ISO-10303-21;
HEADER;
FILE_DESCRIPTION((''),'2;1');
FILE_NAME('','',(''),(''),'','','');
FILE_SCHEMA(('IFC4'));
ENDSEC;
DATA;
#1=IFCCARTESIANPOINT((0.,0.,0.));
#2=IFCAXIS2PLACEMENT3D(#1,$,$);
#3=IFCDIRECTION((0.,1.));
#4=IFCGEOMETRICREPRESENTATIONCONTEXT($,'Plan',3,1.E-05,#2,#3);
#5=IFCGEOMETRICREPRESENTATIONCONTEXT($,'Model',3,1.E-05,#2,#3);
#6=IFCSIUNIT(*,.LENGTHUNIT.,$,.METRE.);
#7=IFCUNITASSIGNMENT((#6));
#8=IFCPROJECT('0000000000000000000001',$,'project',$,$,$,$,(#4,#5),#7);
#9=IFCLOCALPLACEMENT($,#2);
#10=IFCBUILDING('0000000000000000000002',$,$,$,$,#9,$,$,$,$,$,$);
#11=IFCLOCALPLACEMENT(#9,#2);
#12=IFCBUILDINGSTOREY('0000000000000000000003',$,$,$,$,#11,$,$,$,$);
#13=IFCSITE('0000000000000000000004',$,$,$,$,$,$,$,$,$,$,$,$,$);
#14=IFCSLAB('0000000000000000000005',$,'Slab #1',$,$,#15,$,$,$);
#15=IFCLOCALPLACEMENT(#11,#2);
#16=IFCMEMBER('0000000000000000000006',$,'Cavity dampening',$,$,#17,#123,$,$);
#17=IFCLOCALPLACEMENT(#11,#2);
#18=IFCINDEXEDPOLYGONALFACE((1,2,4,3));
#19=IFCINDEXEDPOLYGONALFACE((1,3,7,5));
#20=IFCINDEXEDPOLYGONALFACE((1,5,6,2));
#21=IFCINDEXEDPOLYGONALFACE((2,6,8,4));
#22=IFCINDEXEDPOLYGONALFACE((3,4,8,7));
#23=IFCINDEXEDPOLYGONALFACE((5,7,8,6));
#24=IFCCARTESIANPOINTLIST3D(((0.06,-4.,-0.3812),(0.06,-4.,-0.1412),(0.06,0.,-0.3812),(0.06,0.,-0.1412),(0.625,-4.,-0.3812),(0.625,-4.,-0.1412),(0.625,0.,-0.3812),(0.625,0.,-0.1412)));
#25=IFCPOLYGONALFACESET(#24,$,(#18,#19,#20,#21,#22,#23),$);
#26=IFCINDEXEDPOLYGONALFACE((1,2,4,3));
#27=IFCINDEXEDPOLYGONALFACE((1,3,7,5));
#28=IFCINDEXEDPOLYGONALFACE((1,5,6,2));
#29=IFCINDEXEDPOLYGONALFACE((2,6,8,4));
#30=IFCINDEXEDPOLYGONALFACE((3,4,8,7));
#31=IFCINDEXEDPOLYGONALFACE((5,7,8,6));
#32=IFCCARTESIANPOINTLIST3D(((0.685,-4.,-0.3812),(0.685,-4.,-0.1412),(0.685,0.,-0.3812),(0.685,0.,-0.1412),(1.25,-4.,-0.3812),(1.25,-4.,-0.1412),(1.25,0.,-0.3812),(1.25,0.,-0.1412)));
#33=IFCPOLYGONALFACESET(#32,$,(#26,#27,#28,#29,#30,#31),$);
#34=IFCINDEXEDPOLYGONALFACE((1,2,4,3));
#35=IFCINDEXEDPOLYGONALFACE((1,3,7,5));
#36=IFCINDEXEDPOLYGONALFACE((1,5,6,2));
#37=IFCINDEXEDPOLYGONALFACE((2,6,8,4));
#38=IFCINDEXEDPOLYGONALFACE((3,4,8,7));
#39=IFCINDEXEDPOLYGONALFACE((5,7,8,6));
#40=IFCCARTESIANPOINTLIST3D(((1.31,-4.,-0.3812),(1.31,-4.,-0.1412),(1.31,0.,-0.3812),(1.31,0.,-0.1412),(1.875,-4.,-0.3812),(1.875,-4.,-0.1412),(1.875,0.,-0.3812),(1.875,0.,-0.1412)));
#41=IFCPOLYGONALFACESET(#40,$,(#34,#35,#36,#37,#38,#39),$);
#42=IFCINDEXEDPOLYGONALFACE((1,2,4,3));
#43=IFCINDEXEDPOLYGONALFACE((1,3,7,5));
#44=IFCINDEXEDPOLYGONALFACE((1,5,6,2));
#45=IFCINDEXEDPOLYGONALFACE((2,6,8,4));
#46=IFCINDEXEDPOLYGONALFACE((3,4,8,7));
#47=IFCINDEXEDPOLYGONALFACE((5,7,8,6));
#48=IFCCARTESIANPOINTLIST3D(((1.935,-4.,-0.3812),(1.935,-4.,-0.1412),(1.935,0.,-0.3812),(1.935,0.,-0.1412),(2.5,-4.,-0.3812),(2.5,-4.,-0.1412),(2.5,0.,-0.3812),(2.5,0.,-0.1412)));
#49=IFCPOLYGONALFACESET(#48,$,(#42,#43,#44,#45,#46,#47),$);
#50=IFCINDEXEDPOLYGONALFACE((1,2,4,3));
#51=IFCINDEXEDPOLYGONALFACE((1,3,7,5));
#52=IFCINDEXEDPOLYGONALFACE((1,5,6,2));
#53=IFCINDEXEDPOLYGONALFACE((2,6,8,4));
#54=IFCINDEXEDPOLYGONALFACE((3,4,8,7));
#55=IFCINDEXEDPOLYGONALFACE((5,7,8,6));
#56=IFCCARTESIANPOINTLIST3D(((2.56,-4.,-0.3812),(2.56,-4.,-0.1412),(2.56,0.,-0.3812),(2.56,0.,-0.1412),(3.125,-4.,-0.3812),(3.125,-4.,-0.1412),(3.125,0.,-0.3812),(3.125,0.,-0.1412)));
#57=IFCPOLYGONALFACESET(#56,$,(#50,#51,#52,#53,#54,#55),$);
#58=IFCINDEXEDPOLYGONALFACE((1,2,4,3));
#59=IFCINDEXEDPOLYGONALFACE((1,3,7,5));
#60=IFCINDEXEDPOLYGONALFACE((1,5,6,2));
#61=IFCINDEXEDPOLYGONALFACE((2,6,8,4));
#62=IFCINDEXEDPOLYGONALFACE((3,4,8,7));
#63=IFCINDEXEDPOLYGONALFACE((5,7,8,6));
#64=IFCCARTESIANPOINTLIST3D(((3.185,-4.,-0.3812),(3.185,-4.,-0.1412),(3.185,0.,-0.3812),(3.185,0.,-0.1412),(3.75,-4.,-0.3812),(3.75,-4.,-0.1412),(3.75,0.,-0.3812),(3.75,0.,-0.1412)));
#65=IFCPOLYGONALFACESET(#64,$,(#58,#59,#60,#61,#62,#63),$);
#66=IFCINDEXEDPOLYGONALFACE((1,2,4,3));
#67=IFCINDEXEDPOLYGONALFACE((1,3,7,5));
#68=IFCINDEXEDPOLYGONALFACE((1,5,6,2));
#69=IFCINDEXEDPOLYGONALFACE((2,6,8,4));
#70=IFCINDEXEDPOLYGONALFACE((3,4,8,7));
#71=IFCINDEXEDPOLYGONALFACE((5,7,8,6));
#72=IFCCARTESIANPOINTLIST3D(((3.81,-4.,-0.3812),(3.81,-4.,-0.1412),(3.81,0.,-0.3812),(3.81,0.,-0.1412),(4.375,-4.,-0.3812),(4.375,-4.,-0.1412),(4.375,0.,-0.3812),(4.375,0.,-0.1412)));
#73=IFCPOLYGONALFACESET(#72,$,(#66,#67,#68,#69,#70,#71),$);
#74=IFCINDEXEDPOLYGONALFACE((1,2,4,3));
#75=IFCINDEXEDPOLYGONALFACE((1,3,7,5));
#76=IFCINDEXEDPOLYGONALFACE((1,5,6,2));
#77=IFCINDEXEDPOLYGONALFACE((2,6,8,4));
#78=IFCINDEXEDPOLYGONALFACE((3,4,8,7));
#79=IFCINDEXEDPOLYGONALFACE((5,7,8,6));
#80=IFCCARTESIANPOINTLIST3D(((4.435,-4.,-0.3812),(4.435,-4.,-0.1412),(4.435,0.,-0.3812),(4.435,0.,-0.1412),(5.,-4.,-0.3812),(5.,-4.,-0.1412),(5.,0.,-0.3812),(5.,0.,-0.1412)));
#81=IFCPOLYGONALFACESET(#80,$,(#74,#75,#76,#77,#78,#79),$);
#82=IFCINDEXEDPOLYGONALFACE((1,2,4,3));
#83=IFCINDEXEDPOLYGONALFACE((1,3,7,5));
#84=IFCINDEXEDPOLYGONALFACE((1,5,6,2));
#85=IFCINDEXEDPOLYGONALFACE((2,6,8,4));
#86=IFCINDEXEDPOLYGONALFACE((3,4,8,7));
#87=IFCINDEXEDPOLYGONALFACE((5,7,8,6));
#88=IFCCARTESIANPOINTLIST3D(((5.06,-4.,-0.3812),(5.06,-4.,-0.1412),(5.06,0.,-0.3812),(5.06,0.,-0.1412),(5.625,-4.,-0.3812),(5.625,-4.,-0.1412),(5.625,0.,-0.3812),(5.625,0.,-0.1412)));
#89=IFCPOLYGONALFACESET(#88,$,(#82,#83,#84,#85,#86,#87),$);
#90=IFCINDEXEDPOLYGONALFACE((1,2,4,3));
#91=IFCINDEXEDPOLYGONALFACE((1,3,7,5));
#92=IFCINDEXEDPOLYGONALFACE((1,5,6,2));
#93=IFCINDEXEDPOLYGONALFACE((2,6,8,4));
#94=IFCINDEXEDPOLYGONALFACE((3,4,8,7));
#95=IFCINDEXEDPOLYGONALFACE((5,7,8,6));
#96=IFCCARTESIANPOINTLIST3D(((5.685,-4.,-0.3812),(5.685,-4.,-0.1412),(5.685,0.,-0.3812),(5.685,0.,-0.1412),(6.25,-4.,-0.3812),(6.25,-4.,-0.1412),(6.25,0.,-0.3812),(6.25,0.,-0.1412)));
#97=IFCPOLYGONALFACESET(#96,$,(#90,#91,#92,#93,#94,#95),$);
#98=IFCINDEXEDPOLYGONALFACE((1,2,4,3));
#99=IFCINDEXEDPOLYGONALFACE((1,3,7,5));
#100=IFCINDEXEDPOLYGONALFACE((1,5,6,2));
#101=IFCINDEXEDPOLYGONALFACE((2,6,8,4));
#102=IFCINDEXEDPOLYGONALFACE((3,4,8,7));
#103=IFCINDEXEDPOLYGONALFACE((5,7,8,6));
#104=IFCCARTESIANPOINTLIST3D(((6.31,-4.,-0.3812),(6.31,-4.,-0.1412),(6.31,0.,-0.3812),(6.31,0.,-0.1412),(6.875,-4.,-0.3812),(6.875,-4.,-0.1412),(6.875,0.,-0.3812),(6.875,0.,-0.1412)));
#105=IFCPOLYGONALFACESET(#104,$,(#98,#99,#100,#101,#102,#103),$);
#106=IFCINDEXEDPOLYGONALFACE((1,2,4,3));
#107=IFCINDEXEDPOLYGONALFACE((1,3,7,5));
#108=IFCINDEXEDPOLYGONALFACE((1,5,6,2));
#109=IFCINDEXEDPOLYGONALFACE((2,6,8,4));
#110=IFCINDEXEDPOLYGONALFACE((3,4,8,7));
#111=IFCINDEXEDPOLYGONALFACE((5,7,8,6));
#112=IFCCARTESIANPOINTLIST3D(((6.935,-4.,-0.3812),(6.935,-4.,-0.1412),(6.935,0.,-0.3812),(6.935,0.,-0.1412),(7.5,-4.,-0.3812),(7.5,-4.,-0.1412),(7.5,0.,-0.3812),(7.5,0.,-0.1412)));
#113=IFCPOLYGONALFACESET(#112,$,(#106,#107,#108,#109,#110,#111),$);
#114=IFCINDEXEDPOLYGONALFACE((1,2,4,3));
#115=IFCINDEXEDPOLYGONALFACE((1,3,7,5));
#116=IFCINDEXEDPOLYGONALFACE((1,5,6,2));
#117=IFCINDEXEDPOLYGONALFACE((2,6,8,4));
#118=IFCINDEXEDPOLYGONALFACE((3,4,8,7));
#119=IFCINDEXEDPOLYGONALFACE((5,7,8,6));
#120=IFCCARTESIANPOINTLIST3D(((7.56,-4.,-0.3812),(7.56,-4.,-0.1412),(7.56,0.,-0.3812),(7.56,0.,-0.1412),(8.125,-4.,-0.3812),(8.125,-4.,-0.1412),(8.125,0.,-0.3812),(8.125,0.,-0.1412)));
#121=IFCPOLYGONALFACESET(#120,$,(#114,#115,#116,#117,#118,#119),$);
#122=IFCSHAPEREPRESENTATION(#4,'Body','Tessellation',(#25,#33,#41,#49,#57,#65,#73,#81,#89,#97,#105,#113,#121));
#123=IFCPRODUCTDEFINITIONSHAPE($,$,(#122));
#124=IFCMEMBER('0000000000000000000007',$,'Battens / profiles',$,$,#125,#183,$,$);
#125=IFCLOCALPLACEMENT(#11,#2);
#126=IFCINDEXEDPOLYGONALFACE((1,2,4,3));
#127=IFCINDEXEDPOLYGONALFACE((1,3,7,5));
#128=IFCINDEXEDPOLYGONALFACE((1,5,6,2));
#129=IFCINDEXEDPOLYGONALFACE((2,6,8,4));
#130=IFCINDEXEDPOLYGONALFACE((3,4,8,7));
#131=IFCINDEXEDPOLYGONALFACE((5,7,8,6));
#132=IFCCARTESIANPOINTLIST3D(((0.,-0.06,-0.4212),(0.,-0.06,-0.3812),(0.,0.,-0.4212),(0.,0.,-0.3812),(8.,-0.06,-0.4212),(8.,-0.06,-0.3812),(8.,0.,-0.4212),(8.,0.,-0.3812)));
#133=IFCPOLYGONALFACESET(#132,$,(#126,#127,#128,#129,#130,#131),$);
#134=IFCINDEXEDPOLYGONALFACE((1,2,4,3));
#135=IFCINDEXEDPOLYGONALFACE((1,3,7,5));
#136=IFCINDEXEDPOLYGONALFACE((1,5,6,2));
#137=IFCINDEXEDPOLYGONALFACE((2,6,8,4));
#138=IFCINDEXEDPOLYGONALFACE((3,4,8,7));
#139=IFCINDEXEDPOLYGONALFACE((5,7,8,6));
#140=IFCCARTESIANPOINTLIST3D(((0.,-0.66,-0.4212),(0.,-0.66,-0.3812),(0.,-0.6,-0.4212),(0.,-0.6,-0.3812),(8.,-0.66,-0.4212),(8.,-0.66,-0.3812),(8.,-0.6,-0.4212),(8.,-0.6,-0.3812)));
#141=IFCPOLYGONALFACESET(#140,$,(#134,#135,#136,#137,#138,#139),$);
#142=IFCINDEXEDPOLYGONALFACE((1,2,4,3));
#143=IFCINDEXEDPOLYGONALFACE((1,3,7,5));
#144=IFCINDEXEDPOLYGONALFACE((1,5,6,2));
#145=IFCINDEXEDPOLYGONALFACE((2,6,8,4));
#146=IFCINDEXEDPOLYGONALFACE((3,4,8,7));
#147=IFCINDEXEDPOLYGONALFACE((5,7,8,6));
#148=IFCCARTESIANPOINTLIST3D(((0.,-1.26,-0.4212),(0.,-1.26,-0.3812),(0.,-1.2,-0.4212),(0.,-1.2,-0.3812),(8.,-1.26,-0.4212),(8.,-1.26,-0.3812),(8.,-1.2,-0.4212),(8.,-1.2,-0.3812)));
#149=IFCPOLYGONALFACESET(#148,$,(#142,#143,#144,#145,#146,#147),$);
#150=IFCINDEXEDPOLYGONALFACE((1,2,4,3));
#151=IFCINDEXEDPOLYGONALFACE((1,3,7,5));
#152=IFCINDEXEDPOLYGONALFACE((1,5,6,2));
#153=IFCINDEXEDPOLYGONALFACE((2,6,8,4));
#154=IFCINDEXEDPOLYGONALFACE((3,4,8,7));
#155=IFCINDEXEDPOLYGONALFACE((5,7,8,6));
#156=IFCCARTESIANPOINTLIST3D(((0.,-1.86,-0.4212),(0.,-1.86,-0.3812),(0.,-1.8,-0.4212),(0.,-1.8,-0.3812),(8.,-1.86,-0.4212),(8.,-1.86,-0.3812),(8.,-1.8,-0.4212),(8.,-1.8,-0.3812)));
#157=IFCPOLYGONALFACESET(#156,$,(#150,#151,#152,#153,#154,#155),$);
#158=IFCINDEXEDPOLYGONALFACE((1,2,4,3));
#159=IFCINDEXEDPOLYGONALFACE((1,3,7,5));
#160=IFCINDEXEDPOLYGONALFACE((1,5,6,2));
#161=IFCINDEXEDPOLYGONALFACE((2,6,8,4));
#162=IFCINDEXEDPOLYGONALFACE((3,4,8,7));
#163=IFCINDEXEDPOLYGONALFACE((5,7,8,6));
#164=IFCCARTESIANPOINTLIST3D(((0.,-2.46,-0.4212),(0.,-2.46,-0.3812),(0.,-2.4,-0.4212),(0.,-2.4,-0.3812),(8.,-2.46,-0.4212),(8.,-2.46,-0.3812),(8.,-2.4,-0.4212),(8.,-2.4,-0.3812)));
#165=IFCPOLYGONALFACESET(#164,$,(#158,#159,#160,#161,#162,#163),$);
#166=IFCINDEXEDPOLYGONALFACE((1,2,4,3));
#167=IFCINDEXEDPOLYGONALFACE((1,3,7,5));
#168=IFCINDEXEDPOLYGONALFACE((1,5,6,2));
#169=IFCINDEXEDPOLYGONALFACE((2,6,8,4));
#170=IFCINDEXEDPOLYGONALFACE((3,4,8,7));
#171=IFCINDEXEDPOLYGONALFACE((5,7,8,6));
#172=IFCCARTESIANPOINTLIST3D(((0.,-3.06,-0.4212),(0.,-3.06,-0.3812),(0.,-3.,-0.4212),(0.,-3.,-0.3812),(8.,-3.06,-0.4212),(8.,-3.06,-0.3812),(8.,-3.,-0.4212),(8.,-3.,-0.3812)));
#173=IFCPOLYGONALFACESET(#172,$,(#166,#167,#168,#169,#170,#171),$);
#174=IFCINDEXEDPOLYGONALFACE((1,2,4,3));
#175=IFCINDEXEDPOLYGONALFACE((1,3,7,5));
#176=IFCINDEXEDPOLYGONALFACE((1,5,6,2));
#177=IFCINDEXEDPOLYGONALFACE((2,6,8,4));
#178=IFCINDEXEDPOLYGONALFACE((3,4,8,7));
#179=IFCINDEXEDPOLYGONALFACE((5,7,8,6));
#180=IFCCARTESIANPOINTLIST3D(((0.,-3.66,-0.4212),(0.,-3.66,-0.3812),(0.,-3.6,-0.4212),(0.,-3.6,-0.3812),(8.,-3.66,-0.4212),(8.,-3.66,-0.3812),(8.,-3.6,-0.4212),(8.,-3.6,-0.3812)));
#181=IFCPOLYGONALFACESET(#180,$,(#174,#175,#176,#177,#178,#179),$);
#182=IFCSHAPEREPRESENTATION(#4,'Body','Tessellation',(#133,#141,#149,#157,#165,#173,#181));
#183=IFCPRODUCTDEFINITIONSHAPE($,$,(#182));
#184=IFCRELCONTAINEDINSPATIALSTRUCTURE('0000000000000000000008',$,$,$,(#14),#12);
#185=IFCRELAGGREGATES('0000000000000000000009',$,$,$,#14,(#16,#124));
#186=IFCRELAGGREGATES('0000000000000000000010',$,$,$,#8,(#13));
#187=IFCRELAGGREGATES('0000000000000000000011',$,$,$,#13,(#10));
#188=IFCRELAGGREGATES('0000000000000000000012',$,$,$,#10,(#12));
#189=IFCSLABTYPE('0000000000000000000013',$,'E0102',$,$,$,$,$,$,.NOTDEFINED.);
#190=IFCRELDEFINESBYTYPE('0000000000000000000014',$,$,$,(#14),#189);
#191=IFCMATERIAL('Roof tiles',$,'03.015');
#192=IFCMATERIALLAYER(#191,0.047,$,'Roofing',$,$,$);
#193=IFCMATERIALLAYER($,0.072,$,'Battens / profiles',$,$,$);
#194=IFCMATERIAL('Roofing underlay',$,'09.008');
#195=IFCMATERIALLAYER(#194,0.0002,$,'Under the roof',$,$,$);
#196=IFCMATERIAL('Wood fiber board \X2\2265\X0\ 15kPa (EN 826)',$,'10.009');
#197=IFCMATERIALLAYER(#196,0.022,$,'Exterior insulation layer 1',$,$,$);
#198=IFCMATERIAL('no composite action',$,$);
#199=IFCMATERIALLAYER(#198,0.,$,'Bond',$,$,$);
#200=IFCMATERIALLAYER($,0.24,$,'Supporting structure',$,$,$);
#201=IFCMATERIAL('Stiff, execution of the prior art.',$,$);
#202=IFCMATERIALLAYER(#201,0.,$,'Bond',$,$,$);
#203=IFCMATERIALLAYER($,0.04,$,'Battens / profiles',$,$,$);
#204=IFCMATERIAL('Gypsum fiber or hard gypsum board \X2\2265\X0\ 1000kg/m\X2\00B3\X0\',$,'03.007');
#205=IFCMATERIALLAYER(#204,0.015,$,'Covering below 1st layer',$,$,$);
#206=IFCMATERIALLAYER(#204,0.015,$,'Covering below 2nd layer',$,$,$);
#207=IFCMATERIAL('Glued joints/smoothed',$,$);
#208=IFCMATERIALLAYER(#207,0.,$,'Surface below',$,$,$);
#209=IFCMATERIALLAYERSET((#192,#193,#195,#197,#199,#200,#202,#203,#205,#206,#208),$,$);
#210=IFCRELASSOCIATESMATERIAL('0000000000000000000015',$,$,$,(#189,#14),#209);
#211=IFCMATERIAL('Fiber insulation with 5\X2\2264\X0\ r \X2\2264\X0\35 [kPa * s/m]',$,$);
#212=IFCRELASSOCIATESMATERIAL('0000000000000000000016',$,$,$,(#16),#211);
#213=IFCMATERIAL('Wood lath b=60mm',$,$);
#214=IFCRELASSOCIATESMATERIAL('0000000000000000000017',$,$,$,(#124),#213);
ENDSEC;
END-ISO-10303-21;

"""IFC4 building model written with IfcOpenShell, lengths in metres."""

from ifc_helpers import new_model, si_unit, direction, frame, frame_2d, origin, place, context, project, spatial, rectangle, extrude, material, layer, layer_set, type_object, element, aggregate, save


model = new_model("IFC4")

# Units and contexts
plan_context = context("Plan", 3, precision=1e-05, world=origin(), true_north=direction((0.0, 1.0)))
model_context = context("Model", 3, precision=1e-05, world=origin(), true_north=direction((0.0, 1.0)))
ifc_project = project(units=[si_unit("LENGTHUNIT", "METRE")], contexts=[plan_context, model_context])

# Site, building, storey
site = spatial("IfcSite", under=ifc_project)
building_placement = place(None, origin())
building = spatial("IfcBuilding", under=site, at=building_placement)
storey_placement = place(building_placement, origin())
storey = spatial("IfcBuildingStorey", under=building, at=storey_placement)

# Slab, members
ifc_material_1 = material(Name="Roof tiles", Category="03.015")
ifc_layer_1 = layer(ifc_material_1, 0.047, Name="Roofing")
ifc_layer_2 = layer(None, 0.072, Name="Battens / profiles")
ifc_material_2 = material(Name="Roofing underlay", Category="09.008")
ifc_layer_3 = layer(ifc_material_2, 0.0002, Name="Under the roof")
ifc_material_3 = material(Name="Wood fiber board ≥ 15kPa (EN 826)", Category="10.009")
ifc_layer_4 = layer(ifc_material_3, 0.022, Name="Exterior insulation layer 1")
ifc_material_4 = material(Name="no composite action")
ifc_layer_5 = layer(ifc_material_4, 0.0, Name="Bond")
ifc_layer_6 = layer(None, 0.24, Name="Supporting structure")
ifc_material_5 = material(Name="Stiff, execution of the prior art.")
ifc_layer_7 = layer(ifc_material_5, 0.0, Name="Bond")
ifc_layer_8 = layer(None, 0.04, Name="Battens / profiles")
ifc_material_6 = material(Name="Gypsum fiber or hard gypsum board ≥ 1000kg/m³", Category="03.007")
ifc_layer_9 = layer(ifc_material_6, 0.015, Name="Covering below 1st layer")
ifc_layer_10 = layer(ifc_material_6, 0.015, Name="Covering below 2nd layer")
ifc_material_7 = material(Name="Glued joints/smoothed")
ifc_layer_11 = layer(ifc_material_7, 0.0, Name="Surface below")
ifc_layer_set = layer_set([ifc_layer_1, ifc_layer_2, ifc_layer_3, ifc_layer_4, ifc_layer_5, ifc_layer_6, ifc_layer_7, ifc_layer_8, ifc_layer_9, ifc_layer_10, ifc_layer_11])
slab_type = type_object("IfcSlabType", Name="E0102", PredefinedType="NOTDEFINED", material=ifc_layer_set)
slab_placement = place(None, frame((0.0, 0.0, 0.0), z_axis=(0.0, 0.0, -1.0), x_axis=(1.0, 0.0, 0.0)))
slab = element("IfcSlab", 1, at=slab_placement, inside=storey, type_object=slab_type, material=ifc_layer_set, Name="Slab #1")
ifc_material_8 = material(Name="Fiber insulation with 5≤ r ≤35 [kPa * s/m]")
member_1_placement = place(slab_placement, origin())
member_1 = element("IfcMember", 2, at=member_1_placement, material=ifc_material_8, Name="Cavity dampening", context=plan_context, shape_type="SweptSolid", body=[
    extrude(rectangle(XDim=0.565, YDim=0.24, at=frame_2d((0.2825, 0.12), x_axis=(1.0, 0.0))), frame((0.06, 4.0, 0.1412), z_axis=(0.0, -1.0, 0.0), x_axis=(1.0, 0.0, 0.0)), (0.0, 0.0, 1.0), 4.0),
    extrude(rectangle(XDim=0.565, YDim=0.24, at=frame_2d((0.2825, 0.12), x_axis=(1.0, 0.0))), frame((0.685, 4.0, 0.1412), z_axis=(0.0, -1.0, 0.0), x_axis=(1.0, 0.0, 0.0)), (0.0, 0.0, 1.0), 4.0),
    extrude(rectangle(XDim=0.565, YDim=0.24, at=frame_2d((0.2825, 0.12), x_axis=(1.0, 0.0))), frame((1.31, 4.0, 0.1412), z_axis=(0.0, -1.0, 0.0), x_axis=(1.0, 0.0, 0.0)), (0.0, 0.0, 1.0), 4.0),
    extrude(rectangle(XDim=0.565, YDim=0.24, at=frame_2d((0.2825, 0.12), x_axis=(1.0, 0.0))), frame((1.935, 4.0, 0.1412), z_axis=(0.0, -1.0, 0.0), x_axis=(1.0, 0.0, 0.0)), (0.0, 0.0, 1.0), 4.0),
    extrude(rectangle(XDim=0.565, YDim=0.24, at=frame_2d((0.2825, 0.12), x_axis=(1.0, 0.0))), frame((2.56, 4.0, 0.1412), z_axis=(0.0, -1.0, 0.0), x_axis=(1.0, 0.0, 0.0)), (0.0, 0.0, 1.0), 4.0),
    extrude(rectangle(XDim=0.565, YDim=0.24, at=frame_2d((0.2825, 0.12), x_axis=(1.0, 0.0))), frame((3.185, 4.0, 0.1412), z_axis=(0.0, -1.0, 0.0), x_axis=(1.0, 0.0, 0.0)), (0.0, 0.0, 1.0), 4.0),
    extrude(rectangle(XDim=0.565, YDim=0.24, at=frame_2d((0.2825, 0.12), x_axis=(1.0, 0.0))), frame((3.81, 4.0, 0.1412), z_axis=(0.0, -1.0, 0.0), x_axis=(1.0, 0.0, 0.0)), (0.0, 0.0, 1.0), 4.0),
    extrude(rectangle(XDim=0.565, YDim=0.24, at=frame_2d((0.2825, 0.12), x_axis=(1.0, 0.0))), frame((4.435, 4.0, 0.1412), z_axis=(0.0, -1.0, 0.0), x_axis=(1.0, 0.0, 0.0)), (0.0, 0.0, 1.0), 4.0),
    extrude(rectangle(XDim=0.565, YDim=0.24, at=frame_2d((0.2825, 0.12), x_axis=(1.0, 0.0))), frame((5.06, 4.0, 0.1412), z_axis=(0.0, -1.0, 0.0), x_axis=(1.0, 0.0, 0.0)), (0.0, 0.0, 1.0), 4.0),
    extrude(rectangle(XDim=0.565, YDim=0.24, at=frame_2d((0.2825, 0.12), x_axis=(1.0, 0.0))), frame((5.685, 4.0, 0.1412), z_axis=(0.0, -1.0, 0.0), x_axis=(1.0, 0.0, 0.0)), (0.0, 0.0, 1.0), 4.0),
    extrude(rectangle(XDim=0.565, YDim=0.24, at=frame_2d((0.2825, 0.12), x_axis=(1.0, 0.0))), frame((6.31, 4.0, 0.1412), z_axis=(0.0, -1.0, 0.0), x_axis=(1.0, 0.0, 0.0)), (0.0, 0.0, 1.0), 4.0),
    extrude(rectangle(XDim=0.565, YDim=0.24, at=frame_2d((0.2825, 0.12), x_axis=(1.0, 0.0))), frame((6.935, 4.0, 0.1412), z_axis=(0.0, -1.0, 0.0), x_axis=(1.0, 0.0, 0.0)), (0.0, 0.0, 1.0), 4.0),
    extrude(rectangle(XDim=0.565, YDim=0.24, at=frame_2d((0.2825, 0.12), x_axis=(1.0, 0.0))), frame((7.56, 4.0, 0.1412), z_axis=(0.0, -1.0, 0.0), x_axis=(1.0, 0.0, 0.0)), (0.0, 0.0, 1.0), 4.0),
])
ifc_material_9 = material(Name="Wood lath b=60mm")
member_2_placement = place(slab_placement, origin())
member_2 = element("IfcMember", 3, at=member_2_placement, material=ifc_material_9, Name="Battens / profiles", context=plan_context, shape_type="SweptSolid", body=[
    extrude(rectangle(XDim=0.06, YDim=0.04, at=frame_2d((0.03, 0.02), x_axis=(1.0, 0.0))), frame((0.0, 0.0, 0.3812), z_axis=(1.0, 0.0, 0.0), x_axis=(0.0, 1.0, 0.0)), (0.0, 0.0, 1.0), 8.0),
    extrude(rectangle(XDim=0.06, YDim=0.04, at=frame_2d((0.03, 0.02), x_axis=(1.0, 0.0))), frame((0.0, 0.6, 0.3812), z_axis=(1.0, 0.0, 0.0), x_axis=(0.0, 1.0, 0.0)), (0.0, 0.0, 1.0), 8.0),
    extrude(rectangle(XDim=0.06, YDim=0.04, at=frame_2d((0.03, 0.02), x_axis=(1.0, 0.0))), frame((0.0, 1.2, 0.3812), z_axis=(1.0, 0.0, 0.0), x_axis=(0.0, 1.0, 0.0)), (0.0, 0.0, 1.0), 8.0),
    extrude(rectangle(XDim=0.06, YDim=0.04, at=frame_2d((0.03, 0.02), x_axis=(1.0, 0.0))), frame((0.0, 1.8, 0.3812), z_axis=(1.0, 0.0, 0.0), x_axis=(0.0, 1.0, 0.0)), (0.0, 0.0, 1.0), 8.0),
    extrude(rectangle(XDim=0.06, YDim=0.04, at=frame_2d((0.03, 0.02), x_axis=(1.0, 0.0))), frame((0.0, 2.4, 0.3812), z_axis=(1.0, 0.0, 0.0), x_axis=(0.0, 1.0, 0.0)), (0.0, 0.0, 1.0), 8.0),
    extrude(rectangle(XDim=0.06, YDim=0.04, at=frame_2d((0.03, 0.02), x_axis=(1.0, 0.0))), frame((0.0, 3.0, 0.3812), z_axis=(1.0, 0.0, 0.0), x_axis=(0.0, 1.0, 0.0)), (0.0, 0.0, 1.0), 8.0),
    extrude(rectangle(XDim=0.06, YDim=0.04, at=frame_2d((0.03, 0.02), x_axis=(1.0, 0.0))), frame((0.0, 3.6, 0.3812), z_axis=(1.0, 0.0, 0.0), x_axis=(0.0, 1.0, 0.0)), (0.0, 0.0, 1.0), 8.0),
])
aggregate(slab, [member_1, member_2])

save(model, "model.ifc")
